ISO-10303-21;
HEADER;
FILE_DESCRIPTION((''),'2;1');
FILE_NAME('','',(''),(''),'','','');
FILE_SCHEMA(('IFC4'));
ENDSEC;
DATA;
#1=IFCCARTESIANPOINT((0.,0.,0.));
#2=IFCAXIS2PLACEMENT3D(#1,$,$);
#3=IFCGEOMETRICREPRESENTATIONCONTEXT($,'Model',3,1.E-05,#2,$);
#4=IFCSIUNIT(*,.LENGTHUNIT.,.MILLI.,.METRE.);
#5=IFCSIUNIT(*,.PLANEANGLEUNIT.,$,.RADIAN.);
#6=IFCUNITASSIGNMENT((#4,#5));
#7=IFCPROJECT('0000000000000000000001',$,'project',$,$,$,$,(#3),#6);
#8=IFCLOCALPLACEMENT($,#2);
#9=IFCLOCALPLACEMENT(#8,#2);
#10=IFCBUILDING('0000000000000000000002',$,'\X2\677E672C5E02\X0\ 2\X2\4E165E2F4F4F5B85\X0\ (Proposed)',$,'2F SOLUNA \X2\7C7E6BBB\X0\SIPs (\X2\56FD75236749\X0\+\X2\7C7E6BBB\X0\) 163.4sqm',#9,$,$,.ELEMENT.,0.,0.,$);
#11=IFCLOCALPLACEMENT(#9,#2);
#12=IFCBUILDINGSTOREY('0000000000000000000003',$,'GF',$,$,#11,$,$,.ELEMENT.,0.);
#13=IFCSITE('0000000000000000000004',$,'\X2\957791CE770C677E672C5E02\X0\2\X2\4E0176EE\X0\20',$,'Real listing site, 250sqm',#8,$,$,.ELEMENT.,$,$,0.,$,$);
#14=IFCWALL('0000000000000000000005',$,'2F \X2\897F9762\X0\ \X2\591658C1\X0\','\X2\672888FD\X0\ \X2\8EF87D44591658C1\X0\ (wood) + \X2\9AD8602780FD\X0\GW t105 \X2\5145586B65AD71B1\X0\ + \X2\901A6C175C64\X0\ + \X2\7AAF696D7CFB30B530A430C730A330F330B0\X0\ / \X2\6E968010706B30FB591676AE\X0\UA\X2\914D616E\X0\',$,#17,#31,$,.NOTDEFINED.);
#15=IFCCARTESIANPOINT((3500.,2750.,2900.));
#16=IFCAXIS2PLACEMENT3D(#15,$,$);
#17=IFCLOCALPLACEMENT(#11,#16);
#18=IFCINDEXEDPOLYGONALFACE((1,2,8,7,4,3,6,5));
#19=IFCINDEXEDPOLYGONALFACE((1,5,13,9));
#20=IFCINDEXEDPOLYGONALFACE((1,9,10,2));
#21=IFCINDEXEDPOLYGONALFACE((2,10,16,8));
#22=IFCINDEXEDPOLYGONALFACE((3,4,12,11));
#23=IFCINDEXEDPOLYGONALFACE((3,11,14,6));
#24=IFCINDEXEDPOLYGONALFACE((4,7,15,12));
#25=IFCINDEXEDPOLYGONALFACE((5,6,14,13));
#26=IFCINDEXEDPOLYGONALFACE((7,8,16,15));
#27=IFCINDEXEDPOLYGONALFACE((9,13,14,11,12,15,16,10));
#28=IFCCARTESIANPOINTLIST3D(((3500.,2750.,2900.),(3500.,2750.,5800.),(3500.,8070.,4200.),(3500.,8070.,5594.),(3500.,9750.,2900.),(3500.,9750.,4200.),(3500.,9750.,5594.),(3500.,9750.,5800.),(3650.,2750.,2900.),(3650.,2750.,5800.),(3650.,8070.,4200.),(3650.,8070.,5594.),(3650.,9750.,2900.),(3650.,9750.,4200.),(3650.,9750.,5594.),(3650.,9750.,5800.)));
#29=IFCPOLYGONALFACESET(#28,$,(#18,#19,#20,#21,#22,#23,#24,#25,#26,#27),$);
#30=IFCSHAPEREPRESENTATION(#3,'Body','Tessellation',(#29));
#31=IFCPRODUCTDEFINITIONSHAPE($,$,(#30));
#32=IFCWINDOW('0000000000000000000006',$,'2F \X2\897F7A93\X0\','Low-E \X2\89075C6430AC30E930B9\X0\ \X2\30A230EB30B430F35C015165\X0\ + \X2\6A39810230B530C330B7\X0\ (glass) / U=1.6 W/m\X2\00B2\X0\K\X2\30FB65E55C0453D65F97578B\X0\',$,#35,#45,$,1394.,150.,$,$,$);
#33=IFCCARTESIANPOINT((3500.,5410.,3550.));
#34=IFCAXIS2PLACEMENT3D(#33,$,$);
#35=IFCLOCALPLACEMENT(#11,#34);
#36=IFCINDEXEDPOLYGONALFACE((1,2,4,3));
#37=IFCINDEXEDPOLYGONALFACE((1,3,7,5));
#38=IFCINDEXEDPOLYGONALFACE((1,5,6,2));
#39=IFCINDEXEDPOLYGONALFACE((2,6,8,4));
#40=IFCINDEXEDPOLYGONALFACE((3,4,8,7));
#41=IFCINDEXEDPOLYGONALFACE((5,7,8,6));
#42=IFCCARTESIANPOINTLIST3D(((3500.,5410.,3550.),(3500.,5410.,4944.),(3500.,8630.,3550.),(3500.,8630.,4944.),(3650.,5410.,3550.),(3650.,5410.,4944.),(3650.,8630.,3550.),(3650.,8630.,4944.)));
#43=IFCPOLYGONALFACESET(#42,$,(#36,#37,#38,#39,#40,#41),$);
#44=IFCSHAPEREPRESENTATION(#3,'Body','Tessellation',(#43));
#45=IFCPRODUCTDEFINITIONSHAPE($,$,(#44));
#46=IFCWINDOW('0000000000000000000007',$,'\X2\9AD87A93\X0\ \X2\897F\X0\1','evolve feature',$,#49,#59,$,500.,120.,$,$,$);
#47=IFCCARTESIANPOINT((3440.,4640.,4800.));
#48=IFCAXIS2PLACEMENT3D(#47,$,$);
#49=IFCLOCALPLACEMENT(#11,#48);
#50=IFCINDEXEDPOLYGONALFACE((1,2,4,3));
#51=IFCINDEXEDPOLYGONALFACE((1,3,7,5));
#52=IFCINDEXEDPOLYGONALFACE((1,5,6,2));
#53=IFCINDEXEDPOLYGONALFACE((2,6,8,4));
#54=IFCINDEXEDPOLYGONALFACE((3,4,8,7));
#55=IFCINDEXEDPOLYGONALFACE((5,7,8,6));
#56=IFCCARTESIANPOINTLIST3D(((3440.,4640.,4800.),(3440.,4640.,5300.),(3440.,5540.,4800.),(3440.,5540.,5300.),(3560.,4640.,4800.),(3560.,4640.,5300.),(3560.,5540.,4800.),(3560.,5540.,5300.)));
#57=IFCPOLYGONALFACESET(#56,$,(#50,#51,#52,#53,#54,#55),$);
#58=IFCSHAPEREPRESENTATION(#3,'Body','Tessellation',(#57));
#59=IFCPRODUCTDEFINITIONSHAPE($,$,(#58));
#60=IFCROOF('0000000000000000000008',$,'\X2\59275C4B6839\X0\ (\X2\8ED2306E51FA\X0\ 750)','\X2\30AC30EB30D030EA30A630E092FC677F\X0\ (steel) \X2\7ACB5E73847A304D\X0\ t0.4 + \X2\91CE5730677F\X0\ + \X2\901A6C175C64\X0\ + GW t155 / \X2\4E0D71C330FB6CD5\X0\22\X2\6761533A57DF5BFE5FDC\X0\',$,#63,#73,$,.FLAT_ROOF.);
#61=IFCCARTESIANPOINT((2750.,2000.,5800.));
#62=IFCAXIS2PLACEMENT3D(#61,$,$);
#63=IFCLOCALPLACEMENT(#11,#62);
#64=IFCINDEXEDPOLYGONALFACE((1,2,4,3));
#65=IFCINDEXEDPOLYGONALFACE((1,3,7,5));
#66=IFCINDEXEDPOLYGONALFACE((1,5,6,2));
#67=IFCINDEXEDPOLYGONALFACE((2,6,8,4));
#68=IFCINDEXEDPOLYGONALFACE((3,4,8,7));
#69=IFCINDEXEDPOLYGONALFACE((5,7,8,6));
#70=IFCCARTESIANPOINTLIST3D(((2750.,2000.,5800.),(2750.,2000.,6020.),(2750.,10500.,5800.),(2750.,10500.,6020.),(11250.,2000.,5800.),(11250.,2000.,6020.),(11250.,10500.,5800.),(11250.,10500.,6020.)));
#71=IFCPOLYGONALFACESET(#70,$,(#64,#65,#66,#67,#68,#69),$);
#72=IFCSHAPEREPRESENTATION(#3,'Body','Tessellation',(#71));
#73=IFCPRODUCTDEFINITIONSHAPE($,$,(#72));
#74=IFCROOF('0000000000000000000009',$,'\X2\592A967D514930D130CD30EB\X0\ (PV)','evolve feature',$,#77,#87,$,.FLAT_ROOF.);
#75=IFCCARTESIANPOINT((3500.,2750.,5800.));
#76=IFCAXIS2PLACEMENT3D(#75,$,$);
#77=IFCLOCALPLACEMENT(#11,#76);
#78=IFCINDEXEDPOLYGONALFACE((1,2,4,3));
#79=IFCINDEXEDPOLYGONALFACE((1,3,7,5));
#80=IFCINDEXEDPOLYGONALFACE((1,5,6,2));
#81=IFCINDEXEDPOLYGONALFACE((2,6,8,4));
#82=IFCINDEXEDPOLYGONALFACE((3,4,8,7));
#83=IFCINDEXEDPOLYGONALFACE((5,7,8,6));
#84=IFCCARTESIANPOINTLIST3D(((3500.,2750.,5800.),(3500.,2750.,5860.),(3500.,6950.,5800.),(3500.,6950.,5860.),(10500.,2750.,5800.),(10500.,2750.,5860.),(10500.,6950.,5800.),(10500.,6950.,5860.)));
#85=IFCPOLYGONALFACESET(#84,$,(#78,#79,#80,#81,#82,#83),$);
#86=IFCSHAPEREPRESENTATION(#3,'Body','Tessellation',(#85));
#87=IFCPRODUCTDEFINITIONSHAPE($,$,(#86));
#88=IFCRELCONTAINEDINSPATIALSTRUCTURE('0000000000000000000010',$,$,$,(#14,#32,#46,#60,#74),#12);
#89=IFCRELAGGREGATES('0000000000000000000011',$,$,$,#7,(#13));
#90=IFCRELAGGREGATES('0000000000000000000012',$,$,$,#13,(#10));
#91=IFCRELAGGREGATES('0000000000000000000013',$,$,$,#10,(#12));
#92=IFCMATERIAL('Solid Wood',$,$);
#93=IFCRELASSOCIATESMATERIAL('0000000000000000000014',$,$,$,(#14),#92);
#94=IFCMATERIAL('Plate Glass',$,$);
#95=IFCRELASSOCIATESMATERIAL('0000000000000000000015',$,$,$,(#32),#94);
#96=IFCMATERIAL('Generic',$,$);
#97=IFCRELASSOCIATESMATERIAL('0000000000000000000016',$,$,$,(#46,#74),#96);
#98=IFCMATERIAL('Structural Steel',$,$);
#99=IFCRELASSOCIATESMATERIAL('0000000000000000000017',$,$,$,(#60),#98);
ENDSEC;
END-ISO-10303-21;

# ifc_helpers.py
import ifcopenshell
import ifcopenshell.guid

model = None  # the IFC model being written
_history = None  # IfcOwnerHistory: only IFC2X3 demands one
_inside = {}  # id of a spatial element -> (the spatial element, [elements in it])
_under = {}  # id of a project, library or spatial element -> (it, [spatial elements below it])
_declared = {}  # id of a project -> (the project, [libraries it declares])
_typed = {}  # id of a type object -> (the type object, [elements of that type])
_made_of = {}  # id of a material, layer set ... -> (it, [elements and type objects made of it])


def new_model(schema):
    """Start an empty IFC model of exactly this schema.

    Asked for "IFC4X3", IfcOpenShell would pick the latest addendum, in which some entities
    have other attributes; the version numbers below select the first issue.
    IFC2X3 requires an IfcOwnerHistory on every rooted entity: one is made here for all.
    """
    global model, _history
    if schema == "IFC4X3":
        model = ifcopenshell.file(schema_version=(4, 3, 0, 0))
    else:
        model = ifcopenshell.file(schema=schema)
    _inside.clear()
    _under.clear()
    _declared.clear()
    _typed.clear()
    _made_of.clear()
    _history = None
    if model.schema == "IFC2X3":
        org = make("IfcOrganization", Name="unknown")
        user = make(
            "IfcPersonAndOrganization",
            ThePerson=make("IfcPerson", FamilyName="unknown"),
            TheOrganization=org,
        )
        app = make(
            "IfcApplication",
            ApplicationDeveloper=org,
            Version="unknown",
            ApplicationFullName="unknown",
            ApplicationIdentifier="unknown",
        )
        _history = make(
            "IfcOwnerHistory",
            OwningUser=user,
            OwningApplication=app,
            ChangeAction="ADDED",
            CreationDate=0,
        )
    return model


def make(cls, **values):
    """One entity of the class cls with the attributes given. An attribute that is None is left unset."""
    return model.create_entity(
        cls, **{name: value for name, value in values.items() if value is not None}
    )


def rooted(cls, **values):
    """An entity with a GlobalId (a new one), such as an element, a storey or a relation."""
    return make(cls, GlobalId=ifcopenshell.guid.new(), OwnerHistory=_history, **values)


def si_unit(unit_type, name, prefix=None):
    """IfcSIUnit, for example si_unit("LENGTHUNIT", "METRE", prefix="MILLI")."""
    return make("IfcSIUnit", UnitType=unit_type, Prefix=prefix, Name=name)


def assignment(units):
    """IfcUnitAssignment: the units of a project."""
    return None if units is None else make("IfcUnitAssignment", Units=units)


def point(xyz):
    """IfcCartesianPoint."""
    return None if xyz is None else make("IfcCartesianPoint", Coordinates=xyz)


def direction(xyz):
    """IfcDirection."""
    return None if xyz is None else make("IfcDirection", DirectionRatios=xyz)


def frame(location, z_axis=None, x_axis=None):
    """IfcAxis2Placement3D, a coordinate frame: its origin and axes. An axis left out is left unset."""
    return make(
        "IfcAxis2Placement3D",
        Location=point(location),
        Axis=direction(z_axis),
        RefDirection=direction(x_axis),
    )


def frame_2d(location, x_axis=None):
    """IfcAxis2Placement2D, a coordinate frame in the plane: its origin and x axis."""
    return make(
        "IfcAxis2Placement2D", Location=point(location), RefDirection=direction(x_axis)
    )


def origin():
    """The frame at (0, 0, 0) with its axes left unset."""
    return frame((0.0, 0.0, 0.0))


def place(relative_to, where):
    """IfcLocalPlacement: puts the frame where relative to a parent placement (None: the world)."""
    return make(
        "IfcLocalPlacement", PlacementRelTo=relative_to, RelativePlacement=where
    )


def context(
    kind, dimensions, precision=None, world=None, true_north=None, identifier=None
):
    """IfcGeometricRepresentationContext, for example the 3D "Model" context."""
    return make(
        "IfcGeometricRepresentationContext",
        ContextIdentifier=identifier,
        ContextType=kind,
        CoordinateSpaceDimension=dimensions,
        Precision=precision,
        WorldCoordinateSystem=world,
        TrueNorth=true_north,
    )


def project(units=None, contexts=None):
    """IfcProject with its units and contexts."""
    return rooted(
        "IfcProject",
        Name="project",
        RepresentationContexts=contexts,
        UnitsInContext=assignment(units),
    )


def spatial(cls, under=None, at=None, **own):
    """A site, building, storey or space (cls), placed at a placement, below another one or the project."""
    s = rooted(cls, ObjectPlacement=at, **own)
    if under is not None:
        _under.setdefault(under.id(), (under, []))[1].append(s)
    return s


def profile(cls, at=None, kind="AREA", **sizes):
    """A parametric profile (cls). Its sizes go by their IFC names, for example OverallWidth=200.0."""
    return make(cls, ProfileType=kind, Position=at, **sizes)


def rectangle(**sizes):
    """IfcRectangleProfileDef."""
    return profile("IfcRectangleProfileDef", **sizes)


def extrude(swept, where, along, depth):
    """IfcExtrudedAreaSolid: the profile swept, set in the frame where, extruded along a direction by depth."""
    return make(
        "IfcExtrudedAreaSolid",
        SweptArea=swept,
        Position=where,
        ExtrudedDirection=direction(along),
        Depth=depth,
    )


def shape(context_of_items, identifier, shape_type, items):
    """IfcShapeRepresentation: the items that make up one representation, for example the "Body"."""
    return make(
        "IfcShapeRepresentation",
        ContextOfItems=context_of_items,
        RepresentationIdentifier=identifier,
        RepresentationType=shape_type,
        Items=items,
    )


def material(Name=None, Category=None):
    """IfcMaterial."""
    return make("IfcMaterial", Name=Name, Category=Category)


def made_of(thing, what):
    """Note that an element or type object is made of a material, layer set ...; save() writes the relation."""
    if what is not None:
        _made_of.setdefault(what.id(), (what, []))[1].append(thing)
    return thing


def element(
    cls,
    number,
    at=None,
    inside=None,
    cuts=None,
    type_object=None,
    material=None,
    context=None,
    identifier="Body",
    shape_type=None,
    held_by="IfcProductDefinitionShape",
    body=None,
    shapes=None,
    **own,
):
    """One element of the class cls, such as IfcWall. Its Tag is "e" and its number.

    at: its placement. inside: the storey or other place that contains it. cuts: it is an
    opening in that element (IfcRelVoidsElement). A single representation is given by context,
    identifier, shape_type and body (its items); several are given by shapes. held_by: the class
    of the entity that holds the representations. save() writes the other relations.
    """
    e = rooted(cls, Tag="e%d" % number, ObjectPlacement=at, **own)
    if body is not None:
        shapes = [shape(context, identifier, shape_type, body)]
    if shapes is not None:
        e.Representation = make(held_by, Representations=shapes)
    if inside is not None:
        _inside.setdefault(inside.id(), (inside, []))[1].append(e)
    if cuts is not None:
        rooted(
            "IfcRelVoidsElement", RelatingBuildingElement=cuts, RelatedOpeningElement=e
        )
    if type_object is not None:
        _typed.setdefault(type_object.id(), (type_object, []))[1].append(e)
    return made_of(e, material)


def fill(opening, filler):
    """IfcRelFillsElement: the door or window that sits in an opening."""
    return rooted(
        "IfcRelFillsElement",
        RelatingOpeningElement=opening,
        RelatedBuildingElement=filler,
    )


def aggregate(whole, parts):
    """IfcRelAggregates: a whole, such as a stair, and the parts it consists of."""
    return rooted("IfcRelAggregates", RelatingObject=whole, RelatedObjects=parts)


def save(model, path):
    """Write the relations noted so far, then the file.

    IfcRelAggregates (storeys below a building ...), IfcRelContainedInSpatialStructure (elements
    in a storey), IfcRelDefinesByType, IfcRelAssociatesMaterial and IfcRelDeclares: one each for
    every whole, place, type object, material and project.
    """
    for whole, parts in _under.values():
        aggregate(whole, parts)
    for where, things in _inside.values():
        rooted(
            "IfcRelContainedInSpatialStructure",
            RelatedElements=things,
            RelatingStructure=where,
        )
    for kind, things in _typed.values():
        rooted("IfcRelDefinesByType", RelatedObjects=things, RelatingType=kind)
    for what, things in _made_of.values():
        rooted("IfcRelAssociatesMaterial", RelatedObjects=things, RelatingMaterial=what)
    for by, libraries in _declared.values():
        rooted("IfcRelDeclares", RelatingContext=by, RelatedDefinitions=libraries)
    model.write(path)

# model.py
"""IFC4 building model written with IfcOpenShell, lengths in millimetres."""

from ifc_helpers import new_model, si_unit, frame, frame_2d, origin, place, context, project, spatial, rectangle, extrude, material, element, fill, save


model = new_model("IFC4")

# Units and contexts
model_context = context("Model", 3, precision=1e-05, world=origin())
ifc_project = project(units=[si_unit("LENGTHUNIT", "METRE", prefix="MILLI"), si_unit("PLANEANGLEUNIT", "RADIAN")], contexts=[model_context])

# Site, building, storey
site_placement = place(None, origin())
site = spatial("IfcSite", under=ifc_project, at=site_placement, Name="長野県松本市2丁目20", ObjectType="Real listing site, 250sqm", CompositionType="ELEMENT", RefElevation=0.0)
building_placement = place(site_placement, origin())
building = spatial("IfcBuilding", under=site, at=building_placement, Name="松本市 2世帯住宅 (Proposed)", ObjectType="2F SOLUNA 籾殻SIPs (国産杉+籾殻) 163.4sqm", CompositionType="ELEMENT", ElevationOfRefHeight=0.0, ElevationOfTerrain=0.0)
storey_placement = place(building_placement, origin())
storey = spatial("IfcBuildingStorey", under=building, at=storey_placement, Name="GF", CompositionType="ELEMENT", Elevation=0.0)

# Shared definitions
ifc_material_1 = material(Name="Solid Wood")
ifc_material_2 = material(Name="Generic")

# Shared definitions
ifc_material_3 = material(Name="Plate Glass")

# Wall, openings, windows
wall_1_placement = place(storey_placement, frame((3500.0, 2750.0, 2900.0)))
wall_1 = element("IfcWall", 1, at=wall_1_placement, inside=storey, material=ifc_material_1, Name="2F 西面 外壁", Description="木製 軸組外壁 (wood) + 高性能GW t105 充填断熱 + 通気層 + 窯業系サイディング / 準耐火・外皮UA配慮", PredefinedType="NOTDEFINED", context=model_context, shape_type="SweptSolid", body=[
    extrude(rectangle(XDim=150.0, YDim=7000.0, at=frame_2d((75.0, 3500.0))), frame((3500.0, 2750.0, 2900.0)), (0.0, 0.0, 1.0), 2900.0),
])
opening_1_placement = place(storey_placement, frame((3500.0, 5410.0, 3550.0)))
opening_1 = element("IfcOpeningElement", 2, at=opening_1_placement, cuts=wall_1, PredefinedType="NOTDEFINED", context=model_context, shape_type="SweptSolid", body=[
    extrude(rectangle(XDim=150.0, YDim=3220.0, at=frame_2d((75.0, 1610.0))), frame((3500.0, 5410.0, 3550.0)), (0.0, 0.0, 1.0), 1394.0),
])
opening_2_placement = place(storey_placement, frame((3440.0, 4640.0, 4800.0)))
opening_2 = element("IfcOpeningElement", 3, at=opening_2_placement, cuts=wall_1, PredefinedType="NOTDEFINED", context=model_context, shape_type="SweptSolid", body=[
    extrude(rectangle(XDim=120.0, YDim=900.0, at=frame_2d((60.0, 450.0))), frame((3440.0, 4640.0, 4800.0)), (0.0, 0.0, 1.0), 500.0),
])
window_1_placement = place(storey_placement, frame((3500.0, 5410.0, 3550.0)))
window_1 = element("IfcWindow", 4, at=window_1_placement, inside=storey, material=ifc_material_3, Name="2F 西窓", Description="Low-E 複層ガラス アルゴン封入 + 樹脂サッシ (glass) / U=1.6 W/m²K・日射取得型", OverallHeight=1394.0, OverallWidth=150.0, context=model_context, shape_type="SweptSolid", body=[
    extrude(rectangle(XDim=150.0, YDim=3220.0, at=frame_2d((75.0, 1610.0))), frame((3500.0, 5410.0, 3550.0)), (0.0, 0.0, 1.0), 1394.0),
])
fill(opening_1, window_1)
window_2_placement = place(storey_placement, frame((3440.0, 4640.0, 4800.0)))
window_2 = element("IfcWindow", 5, at=window_2_placement, inside=storey, material=ifc_material_2, Name="高窓 西1", Description="evolve feature", OverallHeight=500.0, OverallWidth=120.0, context=model_context, shape_type="SweptSolid", body=[
    extrude(rectangle(XDim=120.0, YDim=900.0, at=frame_2d((60.0, 450.0))), frame((3440.0, 4640.0, 4800.0)), (0.0, 0.0, 1.0), 500.0),
])
fill(opening_2, window_2)

# Roofs
ifc_material_4 = material(Name="Structural Steel")
roof_1_placement = place(storey_placement, frame((2750.0, 2000.0, 5800.0)))
element("IfcRoof", 6, at=roof_1_placement, inside=storey, material=ifc_material_4, Name="大屋根 (軒の出 750)", Description="ガルバリウム鋼板 (steel) 立平葺き t0.4 + 野地板 + 通気層 + GW t155 / 不燃・法22条区域対応", PredefinedType="FLAT_ROOF", context=model_context, shape_type="SweptSolid", body=[
    extrude(rectangle(XDim=8500.0, YDim=8500.0, at=frame_2d((4250.0, 4250.0))), frame((2750.0, 2000.0, 5800.0)), (0.0, 0.0, 1.0), 220.0),
])
roof_2_placement = place(storey_placement, frame((3500.0, 2750.0, 5800.0)))
element("IfcRoof", 7, at=roof_2_placement, inside=storey, material=ifc_material_2, Name="太陽光パネル (PV)", Description="evolve feature", PredefinedType="FLAT_ROOF", context=model_context, shape_type="SweptSolid", body=[
    extrude(rectangle(XDim=7000.0, YDim=4200.0, at=frame_2d((3500.0, 2100.0))), frame((3500.0, 2750.0, 5800.0)), (0.0, 0.0, 1.0), 60.0),
])

save(model, "model.ifc")
